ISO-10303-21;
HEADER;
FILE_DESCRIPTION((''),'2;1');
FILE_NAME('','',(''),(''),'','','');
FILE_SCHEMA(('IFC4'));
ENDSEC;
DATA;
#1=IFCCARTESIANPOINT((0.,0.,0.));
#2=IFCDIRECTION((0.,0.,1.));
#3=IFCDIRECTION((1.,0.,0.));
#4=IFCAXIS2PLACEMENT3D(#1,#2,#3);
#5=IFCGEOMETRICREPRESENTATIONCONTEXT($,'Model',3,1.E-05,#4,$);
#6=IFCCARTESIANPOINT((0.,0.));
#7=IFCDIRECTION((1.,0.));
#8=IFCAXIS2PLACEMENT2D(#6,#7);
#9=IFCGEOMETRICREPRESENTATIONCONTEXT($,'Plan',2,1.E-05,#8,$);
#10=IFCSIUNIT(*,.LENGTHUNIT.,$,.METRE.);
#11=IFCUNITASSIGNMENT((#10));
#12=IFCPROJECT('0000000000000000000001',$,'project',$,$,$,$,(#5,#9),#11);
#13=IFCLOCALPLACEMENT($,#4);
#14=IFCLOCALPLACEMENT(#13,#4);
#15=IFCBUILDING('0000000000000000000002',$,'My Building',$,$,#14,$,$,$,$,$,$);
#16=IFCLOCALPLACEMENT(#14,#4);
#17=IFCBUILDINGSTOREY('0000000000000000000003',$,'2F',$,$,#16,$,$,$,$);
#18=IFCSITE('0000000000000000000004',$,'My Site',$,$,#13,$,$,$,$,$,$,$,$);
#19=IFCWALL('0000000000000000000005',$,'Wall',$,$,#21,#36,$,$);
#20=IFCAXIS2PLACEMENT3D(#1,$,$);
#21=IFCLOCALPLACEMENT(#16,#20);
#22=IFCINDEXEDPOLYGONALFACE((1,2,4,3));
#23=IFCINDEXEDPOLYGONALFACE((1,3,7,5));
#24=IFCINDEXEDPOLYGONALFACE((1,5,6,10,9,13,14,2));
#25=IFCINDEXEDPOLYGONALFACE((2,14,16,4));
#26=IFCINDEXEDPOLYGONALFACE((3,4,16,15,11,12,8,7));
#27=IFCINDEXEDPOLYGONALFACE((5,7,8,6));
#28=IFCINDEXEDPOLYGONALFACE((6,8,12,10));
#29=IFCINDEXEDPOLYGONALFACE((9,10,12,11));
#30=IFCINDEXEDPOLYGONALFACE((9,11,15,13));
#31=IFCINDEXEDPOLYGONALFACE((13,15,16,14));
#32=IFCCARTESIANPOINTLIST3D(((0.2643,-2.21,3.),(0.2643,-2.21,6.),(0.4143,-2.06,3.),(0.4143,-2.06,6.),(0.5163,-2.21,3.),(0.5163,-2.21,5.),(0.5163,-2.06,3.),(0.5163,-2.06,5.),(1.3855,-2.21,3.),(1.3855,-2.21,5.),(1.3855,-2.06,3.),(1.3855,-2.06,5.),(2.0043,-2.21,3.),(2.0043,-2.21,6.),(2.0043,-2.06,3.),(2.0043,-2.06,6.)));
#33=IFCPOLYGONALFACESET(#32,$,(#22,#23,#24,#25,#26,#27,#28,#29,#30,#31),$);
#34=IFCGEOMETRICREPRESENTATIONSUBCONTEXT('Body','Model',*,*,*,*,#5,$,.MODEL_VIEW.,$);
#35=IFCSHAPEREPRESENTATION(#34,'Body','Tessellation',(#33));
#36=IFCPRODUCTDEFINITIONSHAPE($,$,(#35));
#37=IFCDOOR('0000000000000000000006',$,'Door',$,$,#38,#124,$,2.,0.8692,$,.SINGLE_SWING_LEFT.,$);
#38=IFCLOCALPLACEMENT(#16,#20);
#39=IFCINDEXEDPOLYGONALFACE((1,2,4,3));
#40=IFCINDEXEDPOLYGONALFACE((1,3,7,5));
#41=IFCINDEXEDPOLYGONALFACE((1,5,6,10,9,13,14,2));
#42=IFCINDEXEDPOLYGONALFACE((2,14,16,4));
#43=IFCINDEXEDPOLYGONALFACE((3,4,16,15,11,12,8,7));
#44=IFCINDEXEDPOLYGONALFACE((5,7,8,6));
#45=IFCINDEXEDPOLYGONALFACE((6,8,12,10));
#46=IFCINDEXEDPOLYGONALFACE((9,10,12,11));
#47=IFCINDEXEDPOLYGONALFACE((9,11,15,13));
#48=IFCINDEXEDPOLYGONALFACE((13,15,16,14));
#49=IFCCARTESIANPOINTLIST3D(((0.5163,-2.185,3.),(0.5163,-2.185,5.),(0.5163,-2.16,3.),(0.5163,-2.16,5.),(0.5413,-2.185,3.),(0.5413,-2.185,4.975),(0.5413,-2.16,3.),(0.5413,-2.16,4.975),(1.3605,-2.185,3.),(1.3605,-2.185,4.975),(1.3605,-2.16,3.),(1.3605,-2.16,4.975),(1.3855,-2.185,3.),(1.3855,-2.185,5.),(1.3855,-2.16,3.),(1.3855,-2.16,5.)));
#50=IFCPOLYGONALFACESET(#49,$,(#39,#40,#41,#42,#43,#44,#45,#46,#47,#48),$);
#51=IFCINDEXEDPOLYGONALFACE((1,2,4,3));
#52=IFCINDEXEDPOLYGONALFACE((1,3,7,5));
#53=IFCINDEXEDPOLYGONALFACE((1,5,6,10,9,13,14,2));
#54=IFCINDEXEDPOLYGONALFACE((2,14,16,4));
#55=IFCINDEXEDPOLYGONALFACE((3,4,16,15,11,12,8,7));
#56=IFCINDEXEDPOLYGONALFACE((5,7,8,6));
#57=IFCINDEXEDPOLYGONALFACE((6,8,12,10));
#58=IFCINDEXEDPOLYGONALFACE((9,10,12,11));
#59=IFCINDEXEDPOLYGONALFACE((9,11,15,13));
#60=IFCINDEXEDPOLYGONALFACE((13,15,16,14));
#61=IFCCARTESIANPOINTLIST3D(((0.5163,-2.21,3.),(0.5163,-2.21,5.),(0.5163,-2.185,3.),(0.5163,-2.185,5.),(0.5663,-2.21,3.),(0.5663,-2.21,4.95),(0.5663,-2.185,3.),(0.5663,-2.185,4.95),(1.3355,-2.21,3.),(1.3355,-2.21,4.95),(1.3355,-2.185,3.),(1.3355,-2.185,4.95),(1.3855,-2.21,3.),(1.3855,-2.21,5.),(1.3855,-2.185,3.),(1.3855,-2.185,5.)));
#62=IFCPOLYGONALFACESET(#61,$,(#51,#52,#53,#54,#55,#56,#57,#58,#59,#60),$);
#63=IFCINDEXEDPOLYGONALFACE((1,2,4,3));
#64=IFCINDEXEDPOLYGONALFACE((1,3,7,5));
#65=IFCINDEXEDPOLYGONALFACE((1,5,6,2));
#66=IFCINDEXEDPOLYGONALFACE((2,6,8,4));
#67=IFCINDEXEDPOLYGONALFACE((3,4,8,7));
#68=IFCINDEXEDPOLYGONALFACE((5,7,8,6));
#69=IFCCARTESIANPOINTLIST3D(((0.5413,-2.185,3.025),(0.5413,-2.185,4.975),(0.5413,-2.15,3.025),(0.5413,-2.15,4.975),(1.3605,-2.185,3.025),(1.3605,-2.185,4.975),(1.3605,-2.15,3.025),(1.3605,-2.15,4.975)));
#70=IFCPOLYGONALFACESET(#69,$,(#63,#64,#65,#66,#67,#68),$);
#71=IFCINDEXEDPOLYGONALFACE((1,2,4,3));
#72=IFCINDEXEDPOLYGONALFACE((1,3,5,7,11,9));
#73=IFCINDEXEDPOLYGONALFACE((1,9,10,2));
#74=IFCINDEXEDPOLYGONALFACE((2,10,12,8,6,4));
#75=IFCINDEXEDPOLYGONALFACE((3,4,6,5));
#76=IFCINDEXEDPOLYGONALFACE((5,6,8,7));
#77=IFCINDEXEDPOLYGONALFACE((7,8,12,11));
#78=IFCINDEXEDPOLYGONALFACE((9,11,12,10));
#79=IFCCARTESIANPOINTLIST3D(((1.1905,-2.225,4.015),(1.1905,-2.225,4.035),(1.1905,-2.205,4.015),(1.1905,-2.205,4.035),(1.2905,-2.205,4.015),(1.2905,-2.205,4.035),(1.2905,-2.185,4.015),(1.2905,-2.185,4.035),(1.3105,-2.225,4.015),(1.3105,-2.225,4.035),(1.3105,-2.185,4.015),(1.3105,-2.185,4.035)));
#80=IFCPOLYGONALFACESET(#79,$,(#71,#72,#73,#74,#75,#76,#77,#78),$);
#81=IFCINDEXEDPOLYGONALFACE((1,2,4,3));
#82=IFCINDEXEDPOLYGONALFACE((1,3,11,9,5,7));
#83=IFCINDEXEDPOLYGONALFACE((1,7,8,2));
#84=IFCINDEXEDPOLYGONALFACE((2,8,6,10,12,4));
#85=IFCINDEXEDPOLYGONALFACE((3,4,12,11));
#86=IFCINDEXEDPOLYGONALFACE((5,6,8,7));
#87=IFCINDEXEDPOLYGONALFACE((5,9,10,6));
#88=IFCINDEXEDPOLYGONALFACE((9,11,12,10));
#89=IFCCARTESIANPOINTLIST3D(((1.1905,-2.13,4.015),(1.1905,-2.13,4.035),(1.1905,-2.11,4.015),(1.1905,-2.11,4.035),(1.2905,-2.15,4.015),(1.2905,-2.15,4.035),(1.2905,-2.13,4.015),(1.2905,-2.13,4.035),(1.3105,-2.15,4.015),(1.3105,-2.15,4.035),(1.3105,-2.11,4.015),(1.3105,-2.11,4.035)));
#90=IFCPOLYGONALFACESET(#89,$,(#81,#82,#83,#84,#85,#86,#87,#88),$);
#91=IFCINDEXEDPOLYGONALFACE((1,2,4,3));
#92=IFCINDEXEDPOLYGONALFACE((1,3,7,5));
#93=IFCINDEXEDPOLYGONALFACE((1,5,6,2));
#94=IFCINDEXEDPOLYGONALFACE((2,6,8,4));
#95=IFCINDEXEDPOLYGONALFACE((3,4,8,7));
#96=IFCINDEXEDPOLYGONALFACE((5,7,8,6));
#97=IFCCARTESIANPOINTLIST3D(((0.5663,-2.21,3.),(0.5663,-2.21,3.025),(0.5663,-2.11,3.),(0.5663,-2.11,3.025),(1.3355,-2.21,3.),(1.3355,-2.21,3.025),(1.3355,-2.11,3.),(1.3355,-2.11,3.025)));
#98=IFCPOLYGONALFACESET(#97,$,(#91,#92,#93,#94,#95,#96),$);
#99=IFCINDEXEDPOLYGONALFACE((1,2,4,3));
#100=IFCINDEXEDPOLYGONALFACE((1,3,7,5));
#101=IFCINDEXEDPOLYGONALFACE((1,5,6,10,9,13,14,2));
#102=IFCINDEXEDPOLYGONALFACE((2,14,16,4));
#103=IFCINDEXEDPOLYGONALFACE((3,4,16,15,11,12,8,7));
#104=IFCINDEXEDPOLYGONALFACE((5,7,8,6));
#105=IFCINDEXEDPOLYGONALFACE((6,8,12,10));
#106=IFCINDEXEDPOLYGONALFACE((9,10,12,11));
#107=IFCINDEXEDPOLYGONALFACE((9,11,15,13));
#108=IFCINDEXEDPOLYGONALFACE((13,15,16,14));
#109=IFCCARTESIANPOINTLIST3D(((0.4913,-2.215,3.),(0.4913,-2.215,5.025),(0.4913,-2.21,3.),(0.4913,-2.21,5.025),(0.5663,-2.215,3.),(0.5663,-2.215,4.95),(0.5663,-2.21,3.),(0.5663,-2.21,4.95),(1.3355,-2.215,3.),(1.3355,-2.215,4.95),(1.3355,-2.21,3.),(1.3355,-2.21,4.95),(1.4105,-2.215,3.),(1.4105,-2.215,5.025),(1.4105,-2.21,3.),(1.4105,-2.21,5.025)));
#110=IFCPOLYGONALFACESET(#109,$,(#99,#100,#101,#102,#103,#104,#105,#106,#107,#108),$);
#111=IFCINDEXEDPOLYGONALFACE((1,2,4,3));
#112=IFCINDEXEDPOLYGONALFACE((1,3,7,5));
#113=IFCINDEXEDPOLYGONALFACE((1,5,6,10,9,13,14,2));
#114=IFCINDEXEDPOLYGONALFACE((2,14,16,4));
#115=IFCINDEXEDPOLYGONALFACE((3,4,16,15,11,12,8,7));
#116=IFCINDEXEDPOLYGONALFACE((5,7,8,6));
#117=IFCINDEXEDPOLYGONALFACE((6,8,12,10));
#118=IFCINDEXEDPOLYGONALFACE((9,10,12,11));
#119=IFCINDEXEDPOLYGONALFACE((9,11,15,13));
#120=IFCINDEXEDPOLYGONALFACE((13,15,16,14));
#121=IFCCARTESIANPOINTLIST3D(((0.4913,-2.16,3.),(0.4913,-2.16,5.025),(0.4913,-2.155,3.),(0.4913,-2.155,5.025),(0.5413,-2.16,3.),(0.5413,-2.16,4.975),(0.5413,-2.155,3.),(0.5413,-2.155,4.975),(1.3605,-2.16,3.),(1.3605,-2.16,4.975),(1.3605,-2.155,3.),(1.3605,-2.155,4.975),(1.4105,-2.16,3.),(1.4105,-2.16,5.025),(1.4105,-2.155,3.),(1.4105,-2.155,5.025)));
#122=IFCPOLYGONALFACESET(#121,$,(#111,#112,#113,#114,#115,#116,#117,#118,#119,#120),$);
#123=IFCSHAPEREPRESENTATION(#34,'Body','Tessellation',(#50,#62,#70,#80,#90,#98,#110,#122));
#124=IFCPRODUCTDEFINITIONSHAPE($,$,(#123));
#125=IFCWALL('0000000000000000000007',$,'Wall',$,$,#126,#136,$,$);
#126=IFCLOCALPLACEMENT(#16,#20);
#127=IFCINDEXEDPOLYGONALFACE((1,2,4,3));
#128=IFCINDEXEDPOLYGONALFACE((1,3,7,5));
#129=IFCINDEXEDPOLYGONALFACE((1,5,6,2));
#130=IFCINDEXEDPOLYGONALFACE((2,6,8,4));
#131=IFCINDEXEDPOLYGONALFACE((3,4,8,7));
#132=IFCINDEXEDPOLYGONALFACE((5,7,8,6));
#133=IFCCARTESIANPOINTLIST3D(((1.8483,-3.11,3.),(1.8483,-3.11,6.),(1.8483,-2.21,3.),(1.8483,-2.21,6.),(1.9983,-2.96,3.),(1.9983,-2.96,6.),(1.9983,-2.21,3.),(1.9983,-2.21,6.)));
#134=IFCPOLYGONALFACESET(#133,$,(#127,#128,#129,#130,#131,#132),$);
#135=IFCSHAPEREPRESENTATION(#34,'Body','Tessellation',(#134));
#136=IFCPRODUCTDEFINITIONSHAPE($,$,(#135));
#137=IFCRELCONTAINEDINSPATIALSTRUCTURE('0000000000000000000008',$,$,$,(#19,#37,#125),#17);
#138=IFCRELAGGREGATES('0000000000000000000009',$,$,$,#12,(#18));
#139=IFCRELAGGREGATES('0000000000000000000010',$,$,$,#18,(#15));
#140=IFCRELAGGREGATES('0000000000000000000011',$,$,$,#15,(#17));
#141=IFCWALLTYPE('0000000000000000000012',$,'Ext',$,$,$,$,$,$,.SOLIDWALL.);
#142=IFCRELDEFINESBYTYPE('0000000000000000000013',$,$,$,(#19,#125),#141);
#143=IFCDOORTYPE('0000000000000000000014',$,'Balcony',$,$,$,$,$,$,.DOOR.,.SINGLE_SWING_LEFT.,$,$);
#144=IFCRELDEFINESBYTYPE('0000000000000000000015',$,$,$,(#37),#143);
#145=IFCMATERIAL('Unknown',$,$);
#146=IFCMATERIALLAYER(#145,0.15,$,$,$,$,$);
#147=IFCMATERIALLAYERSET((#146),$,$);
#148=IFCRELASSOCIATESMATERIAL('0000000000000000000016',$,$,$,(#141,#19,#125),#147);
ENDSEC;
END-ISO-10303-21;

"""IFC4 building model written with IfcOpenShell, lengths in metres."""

from ifc_helpers import new_model, entity, si_unit, frame, origin_with_axes, origin_2d_with_axis, place, context, subcontext, project, spatial, line, indexed_curve, outline, extrude, shape, source, transform, mapped, material, layer, layer_set, layer_usage, type_object, type_shapes, element, fill, save


model = new_model("IFC4")

# Units and contexts
model_context = context("Model", 3, precision=1e-05, world=origin_with_axes())
plan_context = context("Plan", 2, precision=1e-05, world=origin_2d_with_axis())
body_context_1 = subcontext(model_context, "Body", "Model", "MODEL_VIEW")
body_context_2 = subcontext(plan_context, "Body", "Plan", "PLAN_VIEW")
ifc_project = project(units=[si_unit("LENGTHUNIT", "METRE")], contexts=[model_context, plan_context])

# Site, building, storey
site_placement = place(None, origin_with_axes())
site = spatial("IfcSite", under=ifc_project, at=site_placement, Name="My Site")
building_placement = place(site_placement, origin_with_axes())
building = spatial("IfcBuilding", under=site, at=building_placement, Name="My Building")
storey_placement = place(building_placement, origin_with_axes())
storey = spatial("IfcBuildingStorey", under=building, at=storey_placement, Name="2F")

# Wall, opening, door
ifc_material = material(Name="Unknown")
ifc_layer_1 = layer(ifc_material, 0.15)
ifc_layer_set_1 = layer_set([ifc_layer_1])
ifc_layer_usage_1 = layer_usage(ifc_layer_set_1, "AXIS2", "POSITIVE", 0.0)
wall_type_1 = type_object("IfcWallType", Name="Ext", PredefinedType="SOLIDWALL", material=ifc_layer_set_1)
wall_1_placement = place(storey_placement, frame((0.2643, -2.21, 3.0), z_axis=(0.0, 0.0, 1.0), x_axis=(1.0, 0.0, 0.0)))
wall_1 = element("IfcWall", 1, at=wall_1_placement, inside=storey, type_object=wall_type_1, material=ifc_layer_usage_1, Name="Wall", context=body_context_1, shape_type="SweptSolid", body=[
    extrude(outline(indexed_curve([(0.0, 0.0), (0.15, 0.15), (1.74, 0.15), (1.74, 0.0)], segments=[line(1, 2, 3, 4, 1)])), origin_with_axes(), (0.0, 0.0, 1.0), 3.0),
])
shared_shape_1 = source(origin_with_axes(), body_context_1, "Body", "SweptSolid", [
    extrude(outline(indexed_curve([(0.0, 0.0), (0.8692, 0.0), (0.8692, 2.0), (0.0, 2.0)], segments=[line(1, 2, 3, 4, 1)])), frame((0.0, -0.6, 0.0), z_axis=(0.0, -1.0, 0.0), x_axis=(1.0, 0.0, 0.0)), (0.0, 0.0, -1.0), 1.2),
])
opening_1_placement = place(wall_1_placement, frame((0.252, 0.0, 0.0), z_axis=(0.0, 0.0, 1.0), x_axis=(1.0, 0.0, 0.0)))
opening_1 = element("IfcOpeningElement", 2, at=opening_1_placement, cuts=wall_1, PredefinedType="OPENING", context=body_context_1, shape_type="MappedRepresentation", body=[
    mapped(shared_shape_1, transform((0.0, 0.0, 0.0), x_axis=(1.0, 0.0, 0.0), y_axis=(0.0, 1.0, 0.0), z_axis=(0.0, 0.0, 1.0), scale=1.0)),
])
door_type_1 = type_object("IfcDoorType", Name="Balcony", OperationType="SINGLE_SWING_LEFT", PredefinedType="DOOR")
shared_shape_2 = source(origin_with_axes(), body_context_1, "Body", "SweptSolid", [
    extrude(outline(indexed_curve([(0.0, 0.0), (0.0, 2.0), (0.8692, 2.0), (0.8692, 0.0), (0.8442, 0.0), (0.8442, 1.975), (0.025, 1.975), (0.025, 0.0)], segments=[line(1, 2, 3, 4, 5, 6, 7, 8, 1)])), frame((0.0, 0.025, 0.0), z_axis=(0.0, -1.0, 0.0), x_axis=(1.0, 0.0, 0.0)), (0.0, 0.0, -1.0), 0.025),
    extrude(outline(indexed_curve([(0.0, 0.0), (0.0, 2.0), (0.8692, 2.0), (0.8692, 0.0), (0.8192, 0.0), (0.8192, 1.95), (0.05, 1.95), (0.05, 0.0)], segments=[line(1, 2, 3, 4, 5, 6, 7, 8, 1)])), frame((0.0, 0.0, 0.0), z_axis=(0.0, -1.0, 0.0), x_axis=(1.0, 0.0, 0.0)), (0.0, 0.0, -1.0), 0.025),
    extrude(outline(indexed_curve([(0.0, 0.0), (0.8192, 0.0), (0.8192, 0.035), (0.0, 0.035)], segments=[line(1, 2, 3, 4, 1)])), frame((0.025, 0.025, 0.025), z_axis=(0.0, 0.0, 1.0), x_axis=(1.0, 0.0, 0.0)), (0.0, 0.0, 1.0), 1.95),
    extrude(outline(indexed_curve([(0.0, 0.0), (0.0, -0.04), (-0.12, -0.04), (-0.12, -0.02), (-0.02, -0.02), (-0.02, 0.0)], segments=[line(1, 2, 3, 4, 5, 6, 1)])), frame((0.7942, 0.025, 1.015), z_axis=(0.0, 0.0, 1.0), x_axis=(1.0, 0.0, 0.0)), (0.0, 0.0, 1.0), 0.02),
    extrude(outline(indexed_curve([(0.0, 0.0), (0.0, 0.04), (-0.12, 0.04), (-0.12, 0.02), (-0.02, 0.02), (-0.02, 0.0)], segments=[line(1, 2, 3, 4, 5, 6, 1)])), frame((0.7942, 0.06, 1.015), z_axis=(0.0, 0.0, 1.0), x_axis=(1.0, 0.0, 0.0)), (0.0, 0.0, 1.0), 0.02),
    extrude(outline(indexed_curve([(0.0, 0.0), (0.7692, 0.0), (0.7692, 0.1), (0.0, 0.1)], segments=[line(1, 2, 3, 4, 1)])), frame((0.05, 0.0, 0.0), z_axis=(0.0, 0.0, 1.0), x_axis=(1.0, 0.0, 0.0)), (0.0, 0.0, 1.0), 0.025),
    extrude(outline(indexed_curve([(0.0, 0.0), (0.0, 2.025), (0.9192, 2.025), (0.9192, 0.0), (0.8442, 0.0), (0.8442, 1.95), (0.075, 1.95), (0.075, 0.0)], segments=[line(1, 2, 3, 4, 5, 6, 7, 8, 1)])), frame((-0.025, -0.005, 0.0), z_axis=(0.0, -1.0, 0.0), x_axis=(1.0, 0.0, 0.0)), (0.0, 0.0, -1.0), 0.005),
    extrude(outline(indexed_curve([(0.0, 0.0), (0.0, 2.025), (0.9192, 2.025), (0.9192, 0.0), (0.8692, 0.0), (0.8692, 1.975), (0.05, 1.975), (0.05, 0.0)], segments=[line(1, 2, 3, 4, 5, 6, 7, 8, 1)])), frame((-0.025, 0.05, 0.0), z_axis=(0.0, -1.0, 0.0), x_axis=(1.0, 0.0, 0.0)), (0.0, 0.0, -1.0), 0.005),
])
shared_shape_3 = source(origin_with_axes(), body_context_2, "Body", "Curve2D", [
    entity("IfcIndexedPolyCurve", entity("IfcCartesianPointList2D", [[0.0, 0.0], [0.0, 0.05], [0.025, 0.05], [0.025, 0.025], [0.05, 0.025], [0.05, 0.0]]), [entity("IfcLineIndex", [1, 2, 3, 4, 5, 6, 1])]),
    entity("IfcIndexedPolyCurve", entity("IfcCartesianPointList2D", [[0.8692, 0.0], [0.8692, 0.05], [0.8442, 0.05], [0.8442, 0.025], [0.8192, 0.025], [0.8192, 0.0]]), [entity("IfcLineIndex", [1, 2, 3, 4, 5, 6, 1])]),
    entity("IfcTrimmedCurve", entity("IfcEllipse", entity("IfcAxis2Placement2D", entity("IfcCartesianPoint", [0.06, 0.05]), entity("IfcDirection", [1.0, 0.0])), 0.7842, 0.8192), [entity("IfcCartesianPoint", [0.8442, 0.05])], [entity("IfcCartesianPoint", [0.06, 0.8692])], True, "CARTESIAN"),
    entity("IfcIndexedPolyCurve", entity("IfcCartesianPointList2D", [[0.025, 0.05], [0.06, 0.05], [0.06, 0.8692], [0.025, 0.8692]]), [entity("IfcLineIndex", [1, 2, 3, 4, 1])]),
])
type_shapes(door_type_1, [shared_shape_2, shared_shape_3])
door_1_placement = place(opening_1_placement, frame((0.0, 0.0, 0.0), z_axis=(0.0, 0.0, 1.0), x_axis=(1.0, 0.0, 0.0)))
door_1 = element("IfcDoor", 3, at=door_1_placement, inside=storey, type_object=door_type_1, Name="Door", OperationType="SINGLE_SWING_LEFT", OverallHeight=2.0, OverallWidth=0.8692, shapes=[
    shape(body_context_1, "Body", "MappedRepresentation", [mapped(shared_shape_2, transform((0.0, 0.0, 0.0), x_axis=(1.0, 0.0, 0.0), y_axis=(0.0, 1.0, 0.0), z_axis=(0.0, 0.0, 1.0), scale=1.0))]),
    shape(body_context_2, "Body", "MappedRepresentation", [mapped(shared_shape_3, transform((0.0, 0.0, 0.0), x_axis=(1.0, 0.0, 0.0), y_axis=(0.0, 1.0, 0.0), z_axis=(0.0, 0.0, 1.0), scale=1.0))]),
])
fill(opening_1, door_1)

# Wall
ifc_layer_usage_2 = layer_usage(ifc_layer_set_1, "AXIS2", "POSITIVE", 0.0)
wall_2_placement = place(storey_placement, frame((1.8483, -2.21, 3.0), z_axis=(0.0, 0.0, 1.0), x_axis=(0.0, -1.0, 0.0)))
element("IfcWall", 4, at=wall_2_placement, inside=storey, type_object=wall_type_1, material=ifc_layer_usage_2, Name="Wall", context=body_context_1, shape_type="SweptSolid", body=[
    extrude(outline(indexed_curve([(0.0, 0.0), (0.0, 0.15), (0.75, 0.15), (0.9, 0.0)], segments=[line(1, 2, 3, 4, 1)])), origin_with_axes(), (0.0, 0.0, 1.0), 3.0),
])

save(model, "model.ifc")
